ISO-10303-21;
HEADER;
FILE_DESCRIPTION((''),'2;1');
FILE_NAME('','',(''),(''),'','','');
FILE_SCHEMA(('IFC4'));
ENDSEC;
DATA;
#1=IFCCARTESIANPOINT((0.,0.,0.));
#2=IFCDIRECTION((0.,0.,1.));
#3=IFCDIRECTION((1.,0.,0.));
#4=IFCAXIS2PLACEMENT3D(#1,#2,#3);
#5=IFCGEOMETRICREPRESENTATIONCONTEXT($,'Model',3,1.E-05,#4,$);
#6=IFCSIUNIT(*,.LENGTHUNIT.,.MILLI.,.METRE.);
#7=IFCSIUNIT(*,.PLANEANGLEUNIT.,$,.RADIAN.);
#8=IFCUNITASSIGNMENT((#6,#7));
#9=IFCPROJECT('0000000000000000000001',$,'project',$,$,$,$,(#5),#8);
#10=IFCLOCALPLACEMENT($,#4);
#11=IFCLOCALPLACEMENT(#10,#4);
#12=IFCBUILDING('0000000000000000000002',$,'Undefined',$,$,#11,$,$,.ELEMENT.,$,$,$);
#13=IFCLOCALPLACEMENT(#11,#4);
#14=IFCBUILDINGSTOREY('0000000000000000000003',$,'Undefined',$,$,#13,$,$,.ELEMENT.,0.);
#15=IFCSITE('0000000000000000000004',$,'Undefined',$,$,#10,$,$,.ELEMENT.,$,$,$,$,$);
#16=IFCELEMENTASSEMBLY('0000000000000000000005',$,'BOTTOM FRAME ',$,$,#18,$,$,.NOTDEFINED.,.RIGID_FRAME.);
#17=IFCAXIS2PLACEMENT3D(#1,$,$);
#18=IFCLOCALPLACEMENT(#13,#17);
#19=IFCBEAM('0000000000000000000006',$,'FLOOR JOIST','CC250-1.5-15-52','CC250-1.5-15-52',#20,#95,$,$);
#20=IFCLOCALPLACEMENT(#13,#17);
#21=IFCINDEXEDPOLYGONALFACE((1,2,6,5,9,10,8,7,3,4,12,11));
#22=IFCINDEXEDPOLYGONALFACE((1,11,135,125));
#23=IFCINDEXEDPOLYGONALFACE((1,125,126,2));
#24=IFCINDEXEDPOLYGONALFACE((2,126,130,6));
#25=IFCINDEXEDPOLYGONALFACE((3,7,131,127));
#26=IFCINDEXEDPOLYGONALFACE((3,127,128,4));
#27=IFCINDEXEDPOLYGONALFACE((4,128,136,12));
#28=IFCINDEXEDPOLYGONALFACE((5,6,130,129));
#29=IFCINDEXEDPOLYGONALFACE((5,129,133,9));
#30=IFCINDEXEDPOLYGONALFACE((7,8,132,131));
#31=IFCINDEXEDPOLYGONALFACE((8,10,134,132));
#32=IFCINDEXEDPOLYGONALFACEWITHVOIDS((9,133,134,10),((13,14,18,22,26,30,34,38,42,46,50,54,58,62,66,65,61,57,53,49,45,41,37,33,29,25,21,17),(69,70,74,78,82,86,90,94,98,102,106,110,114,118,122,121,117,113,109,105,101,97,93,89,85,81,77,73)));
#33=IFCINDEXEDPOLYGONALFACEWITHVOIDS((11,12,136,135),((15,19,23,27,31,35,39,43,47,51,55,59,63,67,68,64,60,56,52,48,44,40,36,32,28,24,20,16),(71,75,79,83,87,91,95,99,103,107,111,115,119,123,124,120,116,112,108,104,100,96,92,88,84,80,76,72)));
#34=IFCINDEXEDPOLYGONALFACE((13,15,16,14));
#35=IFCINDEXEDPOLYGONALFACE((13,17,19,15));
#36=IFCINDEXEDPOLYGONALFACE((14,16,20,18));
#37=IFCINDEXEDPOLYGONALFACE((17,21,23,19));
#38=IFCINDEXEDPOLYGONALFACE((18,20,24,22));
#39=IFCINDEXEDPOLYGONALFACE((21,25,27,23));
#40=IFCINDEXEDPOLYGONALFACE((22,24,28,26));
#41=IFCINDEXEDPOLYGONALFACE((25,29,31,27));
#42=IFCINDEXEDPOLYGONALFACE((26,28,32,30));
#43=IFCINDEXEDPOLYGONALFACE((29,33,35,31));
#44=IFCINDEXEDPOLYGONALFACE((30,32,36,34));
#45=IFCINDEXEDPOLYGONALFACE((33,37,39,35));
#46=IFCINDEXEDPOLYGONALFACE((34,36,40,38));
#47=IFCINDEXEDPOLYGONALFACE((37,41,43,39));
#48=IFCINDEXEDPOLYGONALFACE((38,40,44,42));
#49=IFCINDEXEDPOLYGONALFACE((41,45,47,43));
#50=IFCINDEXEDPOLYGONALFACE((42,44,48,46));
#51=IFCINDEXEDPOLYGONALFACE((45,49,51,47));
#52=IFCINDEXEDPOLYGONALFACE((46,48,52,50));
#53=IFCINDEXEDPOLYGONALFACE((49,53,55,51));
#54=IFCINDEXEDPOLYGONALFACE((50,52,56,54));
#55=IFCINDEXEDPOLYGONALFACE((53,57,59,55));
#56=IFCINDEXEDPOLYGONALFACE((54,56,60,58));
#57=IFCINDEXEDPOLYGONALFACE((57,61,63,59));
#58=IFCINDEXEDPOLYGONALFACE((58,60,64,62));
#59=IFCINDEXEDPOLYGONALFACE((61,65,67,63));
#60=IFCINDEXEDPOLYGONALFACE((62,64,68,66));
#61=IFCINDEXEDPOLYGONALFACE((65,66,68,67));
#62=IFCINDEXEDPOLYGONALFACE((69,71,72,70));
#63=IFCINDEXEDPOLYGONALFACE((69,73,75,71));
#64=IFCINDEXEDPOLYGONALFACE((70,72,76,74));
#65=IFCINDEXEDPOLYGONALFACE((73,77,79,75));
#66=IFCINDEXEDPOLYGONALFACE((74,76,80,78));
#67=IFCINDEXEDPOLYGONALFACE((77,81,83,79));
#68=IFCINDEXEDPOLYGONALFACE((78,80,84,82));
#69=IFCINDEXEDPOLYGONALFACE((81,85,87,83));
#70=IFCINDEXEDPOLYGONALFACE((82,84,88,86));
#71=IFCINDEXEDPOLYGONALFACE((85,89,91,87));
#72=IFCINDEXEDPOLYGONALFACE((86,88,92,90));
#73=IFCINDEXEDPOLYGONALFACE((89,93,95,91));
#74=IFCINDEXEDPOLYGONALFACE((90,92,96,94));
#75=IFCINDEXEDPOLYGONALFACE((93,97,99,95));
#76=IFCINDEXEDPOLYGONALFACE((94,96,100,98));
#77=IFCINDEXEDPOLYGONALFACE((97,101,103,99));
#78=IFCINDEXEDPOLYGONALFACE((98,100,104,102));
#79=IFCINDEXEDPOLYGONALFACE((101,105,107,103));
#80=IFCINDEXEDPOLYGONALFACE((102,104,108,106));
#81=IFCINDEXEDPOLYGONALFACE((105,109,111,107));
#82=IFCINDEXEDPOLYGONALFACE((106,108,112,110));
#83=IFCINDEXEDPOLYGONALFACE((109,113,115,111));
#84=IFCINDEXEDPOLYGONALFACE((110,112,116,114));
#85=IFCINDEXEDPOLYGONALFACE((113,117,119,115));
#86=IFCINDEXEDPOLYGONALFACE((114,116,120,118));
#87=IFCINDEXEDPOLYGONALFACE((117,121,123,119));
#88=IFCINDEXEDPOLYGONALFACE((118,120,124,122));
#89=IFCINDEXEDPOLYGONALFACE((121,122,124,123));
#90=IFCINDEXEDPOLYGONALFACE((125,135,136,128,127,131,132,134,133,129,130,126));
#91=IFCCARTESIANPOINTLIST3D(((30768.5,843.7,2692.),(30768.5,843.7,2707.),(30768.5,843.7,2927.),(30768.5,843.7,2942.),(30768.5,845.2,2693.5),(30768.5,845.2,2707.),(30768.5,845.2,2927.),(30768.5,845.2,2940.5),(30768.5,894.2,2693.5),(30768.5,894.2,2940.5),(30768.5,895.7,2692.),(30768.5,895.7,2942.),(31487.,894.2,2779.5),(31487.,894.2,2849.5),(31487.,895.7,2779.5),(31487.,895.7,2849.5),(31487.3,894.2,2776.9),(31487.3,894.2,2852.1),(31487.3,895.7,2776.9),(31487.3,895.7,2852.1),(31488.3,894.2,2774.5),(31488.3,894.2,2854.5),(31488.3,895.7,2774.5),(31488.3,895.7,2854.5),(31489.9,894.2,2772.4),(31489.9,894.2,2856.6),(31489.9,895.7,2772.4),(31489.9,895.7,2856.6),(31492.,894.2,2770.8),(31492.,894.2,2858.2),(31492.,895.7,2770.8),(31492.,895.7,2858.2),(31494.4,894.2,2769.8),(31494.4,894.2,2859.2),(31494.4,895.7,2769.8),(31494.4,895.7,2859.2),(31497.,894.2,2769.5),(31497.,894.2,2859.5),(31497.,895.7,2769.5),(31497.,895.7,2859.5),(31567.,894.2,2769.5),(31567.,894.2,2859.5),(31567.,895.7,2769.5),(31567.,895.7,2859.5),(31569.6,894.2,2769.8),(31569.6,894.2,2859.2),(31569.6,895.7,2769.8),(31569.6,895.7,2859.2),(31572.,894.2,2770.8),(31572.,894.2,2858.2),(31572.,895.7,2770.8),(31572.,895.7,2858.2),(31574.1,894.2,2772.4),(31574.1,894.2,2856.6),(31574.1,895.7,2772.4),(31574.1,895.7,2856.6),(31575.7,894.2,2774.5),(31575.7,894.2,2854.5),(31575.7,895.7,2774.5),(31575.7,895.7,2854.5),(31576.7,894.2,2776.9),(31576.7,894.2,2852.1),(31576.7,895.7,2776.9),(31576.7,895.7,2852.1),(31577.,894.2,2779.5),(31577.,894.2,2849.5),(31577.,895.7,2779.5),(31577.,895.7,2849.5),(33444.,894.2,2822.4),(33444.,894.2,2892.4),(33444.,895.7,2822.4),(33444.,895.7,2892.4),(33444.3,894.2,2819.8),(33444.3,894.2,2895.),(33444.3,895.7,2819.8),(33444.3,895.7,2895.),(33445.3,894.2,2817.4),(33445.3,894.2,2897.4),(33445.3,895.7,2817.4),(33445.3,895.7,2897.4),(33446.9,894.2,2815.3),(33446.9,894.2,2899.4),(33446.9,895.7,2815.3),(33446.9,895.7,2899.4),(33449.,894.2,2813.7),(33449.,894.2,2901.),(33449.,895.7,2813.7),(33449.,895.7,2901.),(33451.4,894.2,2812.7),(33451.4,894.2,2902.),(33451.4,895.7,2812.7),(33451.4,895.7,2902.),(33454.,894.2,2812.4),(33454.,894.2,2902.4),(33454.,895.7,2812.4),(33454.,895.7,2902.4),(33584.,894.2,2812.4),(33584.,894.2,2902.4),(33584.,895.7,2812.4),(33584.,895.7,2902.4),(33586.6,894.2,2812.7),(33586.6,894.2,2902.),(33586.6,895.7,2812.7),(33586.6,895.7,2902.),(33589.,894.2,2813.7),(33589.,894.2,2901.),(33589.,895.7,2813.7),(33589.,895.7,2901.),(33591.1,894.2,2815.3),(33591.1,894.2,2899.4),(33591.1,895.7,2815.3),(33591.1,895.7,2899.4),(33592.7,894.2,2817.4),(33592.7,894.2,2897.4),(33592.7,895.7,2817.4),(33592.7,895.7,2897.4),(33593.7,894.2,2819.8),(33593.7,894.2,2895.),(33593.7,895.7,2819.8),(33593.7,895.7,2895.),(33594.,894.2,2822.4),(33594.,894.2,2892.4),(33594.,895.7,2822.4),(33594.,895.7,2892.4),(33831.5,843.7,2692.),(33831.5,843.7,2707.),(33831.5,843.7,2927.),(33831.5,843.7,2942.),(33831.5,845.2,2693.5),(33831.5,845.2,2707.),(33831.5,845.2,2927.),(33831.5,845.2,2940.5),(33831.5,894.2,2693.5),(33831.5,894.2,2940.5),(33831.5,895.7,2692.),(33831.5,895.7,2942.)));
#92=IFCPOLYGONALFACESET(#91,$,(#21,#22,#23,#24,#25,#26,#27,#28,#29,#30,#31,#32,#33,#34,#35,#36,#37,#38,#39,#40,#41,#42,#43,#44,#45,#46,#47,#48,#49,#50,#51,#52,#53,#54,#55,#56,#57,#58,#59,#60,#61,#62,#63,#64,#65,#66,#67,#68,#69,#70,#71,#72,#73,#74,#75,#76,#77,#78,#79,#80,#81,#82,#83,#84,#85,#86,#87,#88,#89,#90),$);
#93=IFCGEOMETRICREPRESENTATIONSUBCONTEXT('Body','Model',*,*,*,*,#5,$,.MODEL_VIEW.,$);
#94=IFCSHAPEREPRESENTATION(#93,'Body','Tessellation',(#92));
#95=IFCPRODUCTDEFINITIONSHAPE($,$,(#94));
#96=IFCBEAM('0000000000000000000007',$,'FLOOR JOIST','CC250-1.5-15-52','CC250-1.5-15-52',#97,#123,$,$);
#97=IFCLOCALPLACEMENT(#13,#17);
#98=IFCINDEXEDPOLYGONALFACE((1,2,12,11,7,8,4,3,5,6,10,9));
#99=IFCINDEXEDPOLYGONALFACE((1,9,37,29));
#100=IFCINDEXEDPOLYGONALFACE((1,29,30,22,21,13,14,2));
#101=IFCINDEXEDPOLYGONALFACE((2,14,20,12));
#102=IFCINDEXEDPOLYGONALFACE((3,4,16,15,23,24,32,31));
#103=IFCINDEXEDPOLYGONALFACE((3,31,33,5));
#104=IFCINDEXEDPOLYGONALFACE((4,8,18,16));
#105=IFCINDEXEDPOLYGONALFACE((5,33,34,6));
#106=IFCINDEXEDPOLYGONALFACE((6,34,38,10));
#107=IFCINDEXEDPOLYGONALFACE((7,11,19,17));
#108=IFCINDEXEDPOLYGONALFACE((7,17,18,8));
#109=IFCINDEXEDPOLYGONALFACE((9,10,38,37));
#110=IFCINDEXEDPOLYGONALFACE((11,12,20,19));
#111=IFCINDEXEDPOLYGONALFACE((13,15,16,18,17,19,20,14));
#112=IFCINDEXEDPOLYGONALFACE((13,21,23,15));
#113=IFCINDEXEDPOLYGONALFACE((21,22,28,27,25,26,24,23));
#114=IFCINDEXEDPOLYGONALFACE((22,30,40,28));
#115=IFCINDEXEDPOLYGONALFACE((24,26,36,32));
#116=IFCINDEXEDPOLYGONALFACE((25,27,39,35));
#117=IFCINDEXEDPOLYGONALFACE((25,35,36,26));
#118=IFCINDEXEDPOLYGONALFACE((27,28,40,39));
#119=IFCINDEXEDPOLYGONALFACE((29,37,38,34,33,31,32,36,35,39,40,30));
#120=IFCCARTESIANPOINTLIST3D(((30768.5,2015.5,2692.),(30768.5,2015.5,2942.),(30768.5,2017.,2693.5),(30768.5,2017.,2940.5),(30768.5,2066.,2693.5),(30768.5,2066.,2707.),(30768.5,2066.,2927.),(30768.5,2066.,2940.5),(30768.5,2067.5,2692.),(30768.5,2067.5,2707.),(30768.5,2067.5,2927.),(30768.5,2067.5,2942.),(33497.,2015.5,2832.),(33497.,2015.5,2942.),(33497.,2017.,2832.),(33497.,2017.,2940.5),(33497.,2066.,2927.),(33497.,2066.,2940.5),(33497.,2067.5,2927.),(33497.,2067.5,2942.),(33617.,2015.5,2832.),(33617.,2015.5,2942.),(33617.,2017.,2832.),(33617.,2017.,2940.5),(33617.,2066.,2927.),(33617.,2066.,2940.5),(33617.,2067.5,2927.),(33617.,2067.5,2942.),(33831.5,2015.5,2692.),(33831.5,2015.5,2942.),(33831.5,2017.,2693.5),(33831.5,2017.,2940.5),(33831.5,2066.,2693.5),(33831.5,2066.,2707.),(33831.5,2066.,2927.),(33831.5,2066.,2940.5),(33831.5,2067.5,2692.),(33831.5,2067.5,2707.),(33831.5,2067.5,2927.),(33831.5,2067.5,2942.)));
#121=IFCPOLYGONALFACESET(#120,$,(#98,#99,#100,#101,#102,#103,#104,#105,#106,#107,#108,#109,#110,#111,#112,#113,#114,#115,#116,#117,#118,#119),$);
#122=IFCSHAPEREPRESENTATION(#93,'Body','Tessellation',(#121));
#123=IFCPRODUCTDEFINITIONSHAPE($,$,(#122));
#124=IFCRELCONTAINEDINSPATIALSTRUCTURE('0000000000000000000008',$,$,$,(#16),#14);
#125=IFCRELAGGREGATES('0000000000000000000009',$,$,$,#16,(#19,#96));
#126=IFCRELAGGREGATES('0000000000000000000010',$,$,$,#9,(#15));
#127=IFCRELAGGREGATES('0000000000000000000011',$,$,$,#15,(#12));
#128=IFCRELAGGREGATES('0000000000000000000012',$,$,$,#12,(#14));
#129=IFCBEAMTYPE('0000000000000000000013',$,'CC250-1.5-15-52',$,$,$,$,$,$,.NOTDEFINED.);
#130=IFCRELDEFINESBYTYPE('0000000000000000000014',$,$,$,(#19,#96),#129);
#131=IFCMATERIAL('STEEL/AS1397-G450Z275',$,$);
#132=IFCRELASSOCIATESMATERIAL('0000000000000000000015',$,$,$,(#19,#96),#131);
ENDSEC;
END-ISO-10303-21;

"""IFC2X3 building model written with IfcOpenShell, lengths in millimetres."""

from ifc_helpers import new_model, si_unit, frame, frame_2d, origin_with_axes, origin_2d_with_axis, place, context, subcontext, project, spatial, polyline, circle_curve, parameter, trimmed, segment, composite_curve, c_section, outline, extrude, boolean, material, type_object, element, aggregate, save


model = new_model("IFC2X3")

# Units and contexts
model_context = context("Model", 3, precision=1e-05, world=origin_with_axes())
body_context = subcontext(model_context, "Body", "Model", "MODEL_VIEW")
ifc_project = project(units=[si_unit("LENGTHUNIT", "METRE", prefix="MILLI"), si_unit("PLANEANGLEUNIT", "RADIAN")], contexts=[model_context])

# Site, building, storey
site_placement = place(None, origin_with_axes())
site = spatial("IfcSite", under=ifc_project, at=site_placement, Name="Undefined", CompositionType="ELEMENT")
building_placement = place(site_placement, origin_with_axes())
building = spatial("IfcBuilding", under=site, at=building_placement, Name="Undefined", CompositionType="ELEMENT")
storey_placement = place(building_placement, origin_with_axes())
storey = spatial("IfcBuildingStorey", under=building, at=storey_placement, Name="Undefined", CompositionType="ELEMENT", Elevation=0.0)

# Element assembly, beams
assembly_1_placement = place(storey_placement, origin_with_axes())
assembly_1 = element("IfcElementAssembly", 1, at=assembly_1_placement, inside=storey, Name="BOTTOM FRAME ", AssemblyPlace="NOTDEFINED", PredefinedType="RIGID_FRAME")
ifc_material_1 = material(Name="STEEL/AS1397-G450Z275")
beam_type_1 = type_object("IfcBeamType", Name="CC250-1.5-15-52", PredefinedType="NOTDEFINED")
beam_1_placement = place(assembly_1_placement, frame((30768.5, 869.7, 2817.0), z_axis=(0.0, 0.0, 1.0), x_axis=(1.0, 0.0, 0.0)))
beam_1 = element("IfcBeam", 2, at=beam_1_placement, type_object=beam_type_1, material=ifc_material_1, Name="FLOOR JOIST", Description="CC250-1.5-15-52", ObjectType="CC250-1.5-15-52", context=body_context, shape_type="CSG", body=[
    boolean("DIFFERENCE", boolean("DIFFERENCE", extrude(c_section(Depth=250.0, Width=52.0, WallThickness=1.5, Girth=15.0, at=origin_2d_with_axis()), frame((3063.0, 0.0, 0.0), z_axis=(-1.0, 0.0, 0.0), x_axis=(0.0, -1.0, 0.0)), (0.0, 0.0, 1.0), 3063.0), extrude(outline(composite_curve([segment(trimmed(circle_curve(frame_2d((10.0, 10.0), x_axis=(-1.0, 0.0)), 10.0), [parameter(0.0)], [parameter(1.570796)], True, "PARAMETER"), True, "CONTINUOUS"), segment(polyline([(10.0, 0.0), (80.0, 0.0)]), True, "CONTINUOUS"), segment(trimmed(circle_curve(frame_2d((80.0, 10.0), x_axis=(0.0, -1.0)), 10.0), [parameter(0.0)], [parameter(1.570796)], True, "PARAMETER"), True, "CONTINUOUS"), segment(polyline([(90.0, 10.0), (90.0, 80.0)]), True, "CONTINUOUS"), segment(trimmed(circle_curve(frame_2d((80.0, 80.0), x_axis=(1.0, 0.0)), 10.0), [parameter(0.0)], [parameter(1.570796)], True, "PARAMETER"), True, "CONTINUOUS"), segment(polyline([(80.0, 90.0), (10.0, 90.0)]), True, "CONTINUOUS"), segment(trimmed(circle_curve(frame_2d((10.0, 80.0), x_axis=(0.0, 1.0)), 10.0), [parameter(0.0)], [parameter(1.570796)], True, "PARAMETER"), True, "CONTINUOUS"), segment(polyline([(0.0, 80.0), (0.0, 10.0)]), True, "CONTINUOUS")], self_intersect=True)), frame((718.5, -40.5, 42.5), z_axis=(0.0, 1.0, 0.0), x_axis=(1.0, 0.0, 0.0)), (0.0, 0.0, 1.0), 81.0)), extrude(outline(composite_curve([segment(trimmed(circle_curve(frame_2d((10.0, 10.0), x_axis=(-1.0, 0.0)), 10.0), [parameter(0.0)], [parameter(1.570796)], True, "PARAMETER"), True, "CONTINUOUS"), segment(polyline([(10.0, 0.0), (140.0, 0.0)]), True, "CONTINUOUS"), segment(trimmed(circle_curve(frame_2d((140.0, 10.0), x_axis=(0.0, -1.0)), 10.0), [parameter(0.0)], [parameter(1.570796)], True, "PARAMETER"), True, "CONTINUOUS"), segment(polyline([(150.0, 10.0), (150.0, 80.0)]), True, "CONTINUOUS"), segment(trimmed(circle_curve(frame_2d((140.0, 80.0), x_axis=(1.0, 0.0)), 10.0), [parameter(0.0)], [parameter(1.570796)], True, "PARAMETER"), True, "CONTINUOUS"), segment(polyline([(140.0, 90.0), (10.0, 90.0)]), True, "CONTINUOUS"), segment(trimmed(circle_curve(frame_2d((10.0, 80.0), x_axis=(0.0, 1.0)), 10.0), [parameter(0.0)], [parameter(1.570796)], True, "PARAMETER"), True, "CONTINUOUS"), segment(polyline([(0.0, 80.0), (0.0, 10.0)]), True, "CONTINUOUS")], self_intersect=True)), frame((2675.5, -40.5, 85.4), z_axis=(0.0, 1.0, 0.0), x_axis=(1.0, 0.0, 0.0)), (0.0, 0.0, 1.0), 81.0)),
])
beam_2_placement = place(assembly_1_placement, frame((30768.5, 2041.5, 2817.0), z_axis=(0.0, 0.0, -1.0), x_axis=(1.0, 0.0, 0.0)))
beam_2 = element("IfcBeam", 3, at=beam_2_placement, type_object=beam_type_1, material=ifc_material_1, Name="FLOOR JOIST", Description="CC250-1.5-15-52", ObjectType="CC250-1.5-15-52", context=body_context, shape_type="CSG", body=[
    boolean("DIFFERENCE", extrude(c_section(Depth=250.0, Width=52.0, WallThickness=1.5, Girth=15.0, at=origin_2d_with_axis()), frame((3063.0, 0.0, 0.0), z_axis=(-1.0, 0.0, 0.0), x_axis=(0.0, -1.0, 0.0)), (0.0, 0.0, 1.0), 3063.0), extrude(outline(polyline([(0.0, 0.0), (110.0, 0.0), (110.0, 120.0), (0.0, 120.0), (0.0, 0.0)])), frame((2728.5, -40.5, -125.0), z_axis=(0.0, 1.0, 0.0), x_axis=(0.0, 0.0, 1.0)), (0.0, 0.0, 1.0), 81.0)),
])
aggregate(assembly_1, [beam_1, beam_2])

save(model, "model.ifc")
